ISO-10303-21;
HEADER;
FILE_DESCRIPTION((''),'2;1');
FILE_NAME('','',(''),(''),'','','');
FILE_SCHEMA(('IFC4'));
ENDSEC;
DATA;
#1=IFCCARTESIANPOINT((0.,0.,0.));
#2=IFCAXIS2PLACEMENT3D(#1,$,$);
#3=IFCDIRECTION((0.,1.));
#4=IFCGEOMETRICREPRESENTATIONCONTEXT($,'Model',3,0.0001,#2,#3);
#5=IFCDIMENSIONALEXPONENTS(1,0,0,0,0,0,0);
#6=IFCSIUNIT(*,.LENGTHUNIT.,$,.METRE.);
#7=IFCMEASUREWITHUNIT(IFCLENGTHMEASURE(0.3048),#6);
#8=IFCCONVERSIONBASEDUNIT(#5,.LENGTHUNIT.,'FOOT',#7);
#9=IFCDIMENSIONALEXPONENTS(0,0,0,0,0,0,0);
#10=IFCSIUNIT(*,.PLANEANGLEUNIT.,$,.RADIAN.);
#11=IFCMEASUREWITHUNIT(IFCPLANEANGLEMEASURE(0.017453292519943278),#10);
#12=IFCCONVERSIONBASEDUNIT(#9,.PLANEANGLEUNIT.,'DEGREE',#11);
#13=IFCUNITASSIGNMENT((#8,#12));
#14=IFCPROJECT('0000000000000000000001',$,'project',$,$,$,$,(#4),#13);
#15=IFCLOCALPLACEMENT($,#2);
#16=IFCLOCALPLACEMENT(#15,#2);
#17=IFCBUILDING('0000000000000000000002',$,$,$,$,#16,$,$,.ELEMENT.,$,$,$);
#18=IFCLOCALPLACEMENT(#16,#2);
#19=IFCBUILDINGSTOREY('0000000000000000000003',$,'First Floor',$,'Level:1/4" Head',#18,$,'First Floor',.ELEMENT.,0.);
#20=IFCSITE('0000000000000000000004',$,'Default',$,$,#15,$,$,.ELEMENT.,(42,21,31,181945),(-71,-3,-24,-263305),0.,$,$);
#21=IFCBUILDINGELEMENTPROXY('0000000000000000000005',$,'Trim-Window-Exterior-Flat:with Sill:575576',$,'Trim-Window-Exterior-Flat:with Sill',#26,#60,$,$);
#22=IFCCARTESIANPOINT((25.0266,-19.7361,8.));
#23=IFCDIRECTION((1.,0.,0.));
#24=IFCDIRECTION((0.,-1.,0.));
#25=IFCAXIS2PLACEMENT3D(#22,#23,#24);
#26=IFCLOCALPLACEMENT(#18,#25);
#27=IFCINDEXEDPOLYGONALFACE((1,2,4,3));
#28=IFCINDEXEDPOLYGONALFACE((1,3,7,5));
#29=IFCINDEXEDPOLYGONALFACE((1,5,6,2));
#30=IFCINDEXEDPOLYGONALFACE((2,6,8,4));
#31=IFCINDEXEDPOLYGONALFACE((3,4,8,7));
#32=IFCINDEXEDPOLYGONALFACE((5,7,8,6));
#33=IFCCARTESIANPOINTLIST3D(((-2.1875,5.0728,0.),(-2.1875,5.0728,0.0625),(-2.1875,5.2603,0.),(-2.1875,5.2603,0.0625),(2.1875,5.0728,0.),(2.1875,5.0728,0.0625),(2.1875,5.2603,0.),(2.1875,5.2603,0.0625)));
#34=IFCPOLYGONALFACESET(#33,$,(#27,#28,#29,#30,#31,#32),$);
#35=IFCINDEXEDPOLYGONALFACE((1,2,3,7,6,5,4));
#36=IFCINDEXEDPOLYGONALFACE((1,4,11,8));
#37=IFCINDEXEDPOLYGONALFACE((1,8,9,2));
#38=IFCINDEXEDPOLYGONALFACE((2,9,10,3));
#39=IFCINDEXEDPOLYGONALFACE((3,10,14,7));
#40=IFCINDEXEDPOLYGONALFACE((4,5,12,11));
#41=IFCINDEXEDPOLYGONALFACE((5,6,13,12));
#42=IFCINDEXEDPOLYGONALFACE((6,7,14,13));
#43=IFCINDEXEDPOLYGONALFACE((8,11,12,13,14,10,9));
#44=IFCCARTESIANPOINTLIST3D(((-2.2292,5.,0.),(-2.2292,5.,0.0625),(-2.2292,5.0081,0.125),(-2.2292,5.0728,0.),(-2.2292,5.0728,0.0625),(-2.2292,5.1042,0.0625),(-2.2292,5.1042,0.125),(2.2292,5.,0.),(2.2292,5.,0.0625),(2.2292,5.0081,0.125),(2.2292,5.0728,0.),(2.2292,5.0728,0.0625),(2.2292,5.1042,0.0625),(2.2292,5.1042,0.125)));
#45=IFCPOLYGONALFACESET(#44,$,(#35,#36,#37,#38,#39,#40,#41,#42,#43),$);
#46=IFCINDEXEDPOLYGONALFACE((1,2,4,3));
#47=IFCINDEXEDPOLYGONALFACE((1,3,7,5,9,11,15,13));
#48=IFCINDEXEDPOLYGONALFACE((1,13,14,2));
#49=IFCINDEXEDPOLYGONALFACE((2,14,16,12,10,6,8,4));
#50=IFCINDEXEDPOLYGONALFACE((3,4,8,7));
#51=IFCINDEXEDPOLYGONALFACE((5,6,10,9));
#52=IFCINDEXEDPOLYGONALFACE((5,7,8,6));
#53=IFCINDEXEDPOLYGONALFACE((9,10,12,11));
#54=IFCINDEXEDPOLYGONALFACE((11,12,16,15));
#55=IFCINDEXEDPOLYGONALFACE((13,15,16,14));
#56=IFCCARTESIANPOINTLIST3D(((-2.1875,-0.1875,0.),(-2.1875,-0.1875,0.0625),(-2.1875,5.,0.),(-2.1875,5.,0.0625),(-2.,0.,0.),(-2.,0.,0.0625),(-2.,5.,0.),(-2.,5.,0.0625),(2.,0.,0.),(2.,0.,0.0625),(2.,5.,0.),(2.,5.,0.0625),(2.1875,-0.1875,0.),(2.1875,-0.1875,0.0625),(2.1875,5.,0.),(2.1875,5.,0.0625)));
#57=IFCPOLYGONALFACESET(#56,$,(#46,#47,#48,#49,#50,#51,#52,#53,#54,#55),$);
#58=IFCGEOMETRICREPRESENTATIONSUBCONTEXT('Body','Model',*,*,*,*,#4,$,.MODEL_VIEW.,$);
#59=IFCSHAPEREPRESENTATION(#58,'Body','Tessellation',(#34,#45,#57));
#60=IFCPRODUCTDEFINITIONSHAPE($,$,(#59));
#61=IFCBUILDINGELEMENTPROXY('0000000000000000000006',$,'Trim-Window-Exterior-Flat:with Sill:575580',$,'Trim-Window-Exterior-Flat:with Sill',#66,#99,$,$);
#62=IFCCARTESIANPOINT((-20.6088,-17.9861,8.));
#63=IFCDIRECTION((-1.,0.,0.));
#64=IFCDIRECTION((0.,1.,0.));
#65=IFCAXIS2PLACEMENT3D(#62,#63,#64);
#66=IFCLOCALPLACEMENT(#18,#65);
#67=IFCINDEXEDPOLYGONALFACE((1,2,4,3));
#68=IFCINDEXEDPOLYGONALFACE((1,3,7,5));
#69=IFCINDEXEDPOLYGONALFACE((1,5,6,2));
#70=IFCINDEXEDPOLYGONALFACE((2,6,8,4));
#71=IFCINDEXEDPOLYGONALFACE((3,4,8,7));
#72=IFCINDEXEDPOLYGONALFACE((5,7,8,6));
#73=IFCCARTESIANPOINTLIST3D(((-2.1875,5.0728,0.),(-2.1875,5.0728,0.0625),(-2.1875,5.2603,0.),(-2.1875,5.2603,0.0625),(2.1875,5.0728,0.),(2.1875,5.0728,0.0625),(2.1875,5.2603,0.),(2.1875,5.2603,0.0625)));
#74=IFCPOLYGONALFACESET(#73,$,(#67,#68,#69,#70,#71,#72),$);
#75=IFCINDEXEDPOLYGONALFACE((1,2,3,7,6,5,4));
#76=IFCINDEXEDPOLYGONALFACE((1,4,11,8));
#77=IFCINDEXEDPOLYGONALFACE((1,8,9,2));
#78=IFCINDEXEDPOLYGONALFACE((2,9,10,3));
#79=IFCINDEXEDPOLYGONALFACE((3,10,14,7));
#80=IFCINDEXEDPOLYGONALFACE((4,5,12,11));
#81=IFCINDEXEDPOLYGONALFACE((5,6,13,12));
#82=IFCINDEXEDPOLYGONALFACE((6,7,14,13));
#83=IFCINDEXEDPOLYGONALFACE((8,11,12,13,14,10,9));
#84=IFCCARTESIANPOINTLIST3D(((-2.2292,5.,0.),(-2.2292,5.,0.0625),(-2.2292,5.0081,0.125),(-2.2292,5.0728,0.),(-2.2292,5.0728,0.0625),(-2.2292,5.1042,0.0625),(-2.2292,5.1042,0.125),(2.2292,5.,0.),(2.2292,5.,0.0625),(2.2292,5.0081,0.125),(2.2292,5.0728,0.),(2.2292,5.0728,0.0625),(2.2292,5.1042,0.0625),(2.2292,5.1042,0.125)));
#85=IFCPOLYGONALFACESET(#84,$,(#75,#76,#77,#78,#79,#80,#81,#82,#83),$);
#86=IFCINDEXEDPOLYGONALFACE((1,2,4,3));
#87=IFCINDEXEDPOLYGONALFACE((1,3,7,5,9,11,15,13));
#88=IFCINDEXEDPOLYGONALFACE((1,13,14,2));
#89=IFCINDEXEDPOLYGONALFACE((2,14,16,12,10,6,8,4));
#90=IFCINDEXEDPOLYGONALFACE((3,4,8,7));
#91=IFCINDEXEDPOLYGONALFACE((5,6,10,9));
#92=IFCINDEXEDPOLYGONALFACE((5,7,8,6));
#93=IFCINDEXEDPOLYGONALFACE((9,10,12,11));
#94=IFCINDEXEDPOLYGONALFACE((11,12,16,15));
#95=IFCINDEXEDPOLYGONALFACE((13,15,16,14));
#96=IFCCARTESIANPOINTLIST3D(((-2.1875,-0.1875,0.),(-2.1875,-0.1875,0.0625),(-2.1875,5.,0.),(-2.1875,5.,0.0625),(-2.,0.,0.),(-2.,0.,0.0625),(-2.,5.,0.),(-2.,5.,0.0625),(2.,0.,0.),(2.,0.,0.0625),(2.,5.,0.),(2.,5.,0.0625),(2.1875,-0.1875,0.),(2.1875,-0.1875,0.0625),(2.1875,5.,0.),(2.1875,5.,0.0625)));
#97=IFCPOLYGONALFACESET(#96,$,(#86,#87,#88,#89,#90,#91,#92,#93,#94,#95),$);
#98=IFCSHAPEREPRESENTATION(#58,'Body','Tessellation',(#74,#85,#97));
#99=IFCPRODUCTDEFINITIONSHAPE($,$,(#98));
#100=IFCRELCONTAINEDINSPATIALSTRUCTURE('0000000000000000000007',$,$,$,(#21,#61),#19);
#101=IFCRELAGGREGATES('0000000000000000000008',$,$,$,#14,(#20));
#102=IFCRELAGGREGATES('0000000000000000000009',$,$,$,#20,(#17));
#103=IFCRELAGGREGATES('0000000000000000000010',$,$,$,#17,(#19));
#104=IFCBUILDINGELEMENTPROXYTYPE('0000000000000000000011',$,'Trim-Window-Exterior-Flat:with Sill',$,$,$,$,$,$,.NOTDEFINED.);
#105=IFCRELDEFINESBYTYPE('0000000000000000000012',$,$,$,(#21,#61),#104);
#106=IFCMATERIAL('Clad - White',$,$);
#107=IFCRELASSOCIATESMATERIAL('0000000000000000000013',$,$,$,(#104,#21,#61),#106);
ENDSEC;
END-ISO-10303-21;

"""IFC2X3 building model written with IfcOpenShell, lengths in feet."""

from ifc_helpers import new_model, entity, si_unit, converted_unit, direction, frame, frame_2d, origin, place, context, subcontext, project, spatial, polyline, rectangle, outline, extrude, source, transform, mapped, material, type_object, type_shapes, element, save


model = new_model("IFC2X3")

# Units and contexts
model_context = context("Model", 3, precision=0.0001, world=origin(), true_north=direction((0.0, 1.0)))
body_context = subcontext(model_context, "Body", "Model", "MODEL_VIEW")
ifc_project = project(units=[converted_unit("LENGTHUNIT", "FOOT", entity("IfcLengthMeasure", 0.3048), si_unit("LENGTHUNIT", "METRE"), dimensions=[1, 0, 0, 0, 0, 0, 0]), converted_unit("PLANEANGLEUNIT", "DEGREE", entity("IfcPlaneAngleMeasure", 0.017453292519943278), si_unit("PLANEANGLEUNIT", "RADIAN"), dimensions=[0, 0, 0, 0, 0, 0, 0])], contexts=[model_context])

# Site, building, storey
site_placement = place(None, origin())
site = spatial("IfcSite", under=ifc_project, at=site_placement, Name="Default", CompositionType="ELEMENT", RefLatitude=(42, 21, 31, 181945), RefLongitude=(-71, -3, -24, -263305), RefElevation=0.0)
building_placement = place(site_placement, origin())
building = spatial("IfcBuilding", under=site, at=building_placement, CompositionType="ELEMENT")
storey_placement = place(building_placement, origin())
storey = spatial("IfcBuildingStorey", under=building, at=storey_placement, Name="First Floor", ObjectType="Level:1/4\" Head", LongName="First Floor", CompositionType="ELEMENT", Elevation=0.0)

# Building element proxies
ifc_material_1 = material(Name="Clad - White")
building_element_proxy_type_1 = type_object("IfcBuildingElementProxyType", Name="Trim-Window-Exterior-Flat:with Sill", PredefinedType="NOTDEFINED", material=ifc_material_1)
shared_shape_1 = source(origin(), body_context, "Body", "SweptSolid", [
    extrude(rectangle(XDim=0.1875, YDim=4.375, at=frame_2d((0.0, 0.0), x_axis=(1.0, 0.0))), frame((0.0, 5.1665, 0.0), z_axis=(0.0, 0.0, 1.0), x_axis=(0.0, 1.0, 0.0)), (0.0, 0.0, 1.0), 0.0625),
    extrude(outline(polyline([(-0.0525, -0.0625), (0.0436, -0.0625), (0.0517, 0.0), (0.0517, 0.0625), (-0.0211, 0.0625), (-0.0211, 0.0), (-0.0525, 0.0), (-0.0525, -0.0625)])), frame((-2.2292, 5.0517, 0.0625), z_axis=(1.0, 0.0, 0.0), x_axis=(0.0, -1.0, 0.0)), (0.0, 0.0, 1.0), 4.4583),
    extrude(outline(polyline([(-2.1875, -2.6406), (2.1875, -2.6406), (2.1875, 2.5469), (2.0, 2.5469), (2.0, -2.4531), (-2.0, -2.4531), (-2.0, 2.5469), (-2.1875, 2.5469), (-2.1875, -2.6406)])), frame((0.0, 2.4531, 0.0)), (0.0, 0.0, 1.0), 0.0625),
])
type_shapes(building_element_proxy_type_1, [shared_shape_1])
for number, where, z_axis, x_axis, name in (
    (1, (25.0266, -19.7361, 8.0), (1.0, 0.0, 0.0), (0.0, -1.0, 0.0), "Trim-Window-Exterior-Flat:with Sill:575576"),
    (2, (-20.6088, -17.9861, 8.0), (-1.0, 0.0, 0.0), (0.0, 1.0, 0.0), "Trim-Window-Exterior-Flat:with Sill:575580"),
):
    element("IfcBuildingElementProxy", number, at=place(storey_placement, frame(where, z_axis=z_axis, x_axis=x_axis)), inside=storey, type_object=building_element_proxy_type_1, material=ifc_material_1, Name=name, ObjectType="Trim-Window-Exterior-Flat:with Sill", context=body_context, shape_type="MappedRepresentation", body=[
        mapped(shared_shape_1, transform((0.0, 0.0, 0.0), scale=1.0)),
    ])

save(model, "model.ifc")
